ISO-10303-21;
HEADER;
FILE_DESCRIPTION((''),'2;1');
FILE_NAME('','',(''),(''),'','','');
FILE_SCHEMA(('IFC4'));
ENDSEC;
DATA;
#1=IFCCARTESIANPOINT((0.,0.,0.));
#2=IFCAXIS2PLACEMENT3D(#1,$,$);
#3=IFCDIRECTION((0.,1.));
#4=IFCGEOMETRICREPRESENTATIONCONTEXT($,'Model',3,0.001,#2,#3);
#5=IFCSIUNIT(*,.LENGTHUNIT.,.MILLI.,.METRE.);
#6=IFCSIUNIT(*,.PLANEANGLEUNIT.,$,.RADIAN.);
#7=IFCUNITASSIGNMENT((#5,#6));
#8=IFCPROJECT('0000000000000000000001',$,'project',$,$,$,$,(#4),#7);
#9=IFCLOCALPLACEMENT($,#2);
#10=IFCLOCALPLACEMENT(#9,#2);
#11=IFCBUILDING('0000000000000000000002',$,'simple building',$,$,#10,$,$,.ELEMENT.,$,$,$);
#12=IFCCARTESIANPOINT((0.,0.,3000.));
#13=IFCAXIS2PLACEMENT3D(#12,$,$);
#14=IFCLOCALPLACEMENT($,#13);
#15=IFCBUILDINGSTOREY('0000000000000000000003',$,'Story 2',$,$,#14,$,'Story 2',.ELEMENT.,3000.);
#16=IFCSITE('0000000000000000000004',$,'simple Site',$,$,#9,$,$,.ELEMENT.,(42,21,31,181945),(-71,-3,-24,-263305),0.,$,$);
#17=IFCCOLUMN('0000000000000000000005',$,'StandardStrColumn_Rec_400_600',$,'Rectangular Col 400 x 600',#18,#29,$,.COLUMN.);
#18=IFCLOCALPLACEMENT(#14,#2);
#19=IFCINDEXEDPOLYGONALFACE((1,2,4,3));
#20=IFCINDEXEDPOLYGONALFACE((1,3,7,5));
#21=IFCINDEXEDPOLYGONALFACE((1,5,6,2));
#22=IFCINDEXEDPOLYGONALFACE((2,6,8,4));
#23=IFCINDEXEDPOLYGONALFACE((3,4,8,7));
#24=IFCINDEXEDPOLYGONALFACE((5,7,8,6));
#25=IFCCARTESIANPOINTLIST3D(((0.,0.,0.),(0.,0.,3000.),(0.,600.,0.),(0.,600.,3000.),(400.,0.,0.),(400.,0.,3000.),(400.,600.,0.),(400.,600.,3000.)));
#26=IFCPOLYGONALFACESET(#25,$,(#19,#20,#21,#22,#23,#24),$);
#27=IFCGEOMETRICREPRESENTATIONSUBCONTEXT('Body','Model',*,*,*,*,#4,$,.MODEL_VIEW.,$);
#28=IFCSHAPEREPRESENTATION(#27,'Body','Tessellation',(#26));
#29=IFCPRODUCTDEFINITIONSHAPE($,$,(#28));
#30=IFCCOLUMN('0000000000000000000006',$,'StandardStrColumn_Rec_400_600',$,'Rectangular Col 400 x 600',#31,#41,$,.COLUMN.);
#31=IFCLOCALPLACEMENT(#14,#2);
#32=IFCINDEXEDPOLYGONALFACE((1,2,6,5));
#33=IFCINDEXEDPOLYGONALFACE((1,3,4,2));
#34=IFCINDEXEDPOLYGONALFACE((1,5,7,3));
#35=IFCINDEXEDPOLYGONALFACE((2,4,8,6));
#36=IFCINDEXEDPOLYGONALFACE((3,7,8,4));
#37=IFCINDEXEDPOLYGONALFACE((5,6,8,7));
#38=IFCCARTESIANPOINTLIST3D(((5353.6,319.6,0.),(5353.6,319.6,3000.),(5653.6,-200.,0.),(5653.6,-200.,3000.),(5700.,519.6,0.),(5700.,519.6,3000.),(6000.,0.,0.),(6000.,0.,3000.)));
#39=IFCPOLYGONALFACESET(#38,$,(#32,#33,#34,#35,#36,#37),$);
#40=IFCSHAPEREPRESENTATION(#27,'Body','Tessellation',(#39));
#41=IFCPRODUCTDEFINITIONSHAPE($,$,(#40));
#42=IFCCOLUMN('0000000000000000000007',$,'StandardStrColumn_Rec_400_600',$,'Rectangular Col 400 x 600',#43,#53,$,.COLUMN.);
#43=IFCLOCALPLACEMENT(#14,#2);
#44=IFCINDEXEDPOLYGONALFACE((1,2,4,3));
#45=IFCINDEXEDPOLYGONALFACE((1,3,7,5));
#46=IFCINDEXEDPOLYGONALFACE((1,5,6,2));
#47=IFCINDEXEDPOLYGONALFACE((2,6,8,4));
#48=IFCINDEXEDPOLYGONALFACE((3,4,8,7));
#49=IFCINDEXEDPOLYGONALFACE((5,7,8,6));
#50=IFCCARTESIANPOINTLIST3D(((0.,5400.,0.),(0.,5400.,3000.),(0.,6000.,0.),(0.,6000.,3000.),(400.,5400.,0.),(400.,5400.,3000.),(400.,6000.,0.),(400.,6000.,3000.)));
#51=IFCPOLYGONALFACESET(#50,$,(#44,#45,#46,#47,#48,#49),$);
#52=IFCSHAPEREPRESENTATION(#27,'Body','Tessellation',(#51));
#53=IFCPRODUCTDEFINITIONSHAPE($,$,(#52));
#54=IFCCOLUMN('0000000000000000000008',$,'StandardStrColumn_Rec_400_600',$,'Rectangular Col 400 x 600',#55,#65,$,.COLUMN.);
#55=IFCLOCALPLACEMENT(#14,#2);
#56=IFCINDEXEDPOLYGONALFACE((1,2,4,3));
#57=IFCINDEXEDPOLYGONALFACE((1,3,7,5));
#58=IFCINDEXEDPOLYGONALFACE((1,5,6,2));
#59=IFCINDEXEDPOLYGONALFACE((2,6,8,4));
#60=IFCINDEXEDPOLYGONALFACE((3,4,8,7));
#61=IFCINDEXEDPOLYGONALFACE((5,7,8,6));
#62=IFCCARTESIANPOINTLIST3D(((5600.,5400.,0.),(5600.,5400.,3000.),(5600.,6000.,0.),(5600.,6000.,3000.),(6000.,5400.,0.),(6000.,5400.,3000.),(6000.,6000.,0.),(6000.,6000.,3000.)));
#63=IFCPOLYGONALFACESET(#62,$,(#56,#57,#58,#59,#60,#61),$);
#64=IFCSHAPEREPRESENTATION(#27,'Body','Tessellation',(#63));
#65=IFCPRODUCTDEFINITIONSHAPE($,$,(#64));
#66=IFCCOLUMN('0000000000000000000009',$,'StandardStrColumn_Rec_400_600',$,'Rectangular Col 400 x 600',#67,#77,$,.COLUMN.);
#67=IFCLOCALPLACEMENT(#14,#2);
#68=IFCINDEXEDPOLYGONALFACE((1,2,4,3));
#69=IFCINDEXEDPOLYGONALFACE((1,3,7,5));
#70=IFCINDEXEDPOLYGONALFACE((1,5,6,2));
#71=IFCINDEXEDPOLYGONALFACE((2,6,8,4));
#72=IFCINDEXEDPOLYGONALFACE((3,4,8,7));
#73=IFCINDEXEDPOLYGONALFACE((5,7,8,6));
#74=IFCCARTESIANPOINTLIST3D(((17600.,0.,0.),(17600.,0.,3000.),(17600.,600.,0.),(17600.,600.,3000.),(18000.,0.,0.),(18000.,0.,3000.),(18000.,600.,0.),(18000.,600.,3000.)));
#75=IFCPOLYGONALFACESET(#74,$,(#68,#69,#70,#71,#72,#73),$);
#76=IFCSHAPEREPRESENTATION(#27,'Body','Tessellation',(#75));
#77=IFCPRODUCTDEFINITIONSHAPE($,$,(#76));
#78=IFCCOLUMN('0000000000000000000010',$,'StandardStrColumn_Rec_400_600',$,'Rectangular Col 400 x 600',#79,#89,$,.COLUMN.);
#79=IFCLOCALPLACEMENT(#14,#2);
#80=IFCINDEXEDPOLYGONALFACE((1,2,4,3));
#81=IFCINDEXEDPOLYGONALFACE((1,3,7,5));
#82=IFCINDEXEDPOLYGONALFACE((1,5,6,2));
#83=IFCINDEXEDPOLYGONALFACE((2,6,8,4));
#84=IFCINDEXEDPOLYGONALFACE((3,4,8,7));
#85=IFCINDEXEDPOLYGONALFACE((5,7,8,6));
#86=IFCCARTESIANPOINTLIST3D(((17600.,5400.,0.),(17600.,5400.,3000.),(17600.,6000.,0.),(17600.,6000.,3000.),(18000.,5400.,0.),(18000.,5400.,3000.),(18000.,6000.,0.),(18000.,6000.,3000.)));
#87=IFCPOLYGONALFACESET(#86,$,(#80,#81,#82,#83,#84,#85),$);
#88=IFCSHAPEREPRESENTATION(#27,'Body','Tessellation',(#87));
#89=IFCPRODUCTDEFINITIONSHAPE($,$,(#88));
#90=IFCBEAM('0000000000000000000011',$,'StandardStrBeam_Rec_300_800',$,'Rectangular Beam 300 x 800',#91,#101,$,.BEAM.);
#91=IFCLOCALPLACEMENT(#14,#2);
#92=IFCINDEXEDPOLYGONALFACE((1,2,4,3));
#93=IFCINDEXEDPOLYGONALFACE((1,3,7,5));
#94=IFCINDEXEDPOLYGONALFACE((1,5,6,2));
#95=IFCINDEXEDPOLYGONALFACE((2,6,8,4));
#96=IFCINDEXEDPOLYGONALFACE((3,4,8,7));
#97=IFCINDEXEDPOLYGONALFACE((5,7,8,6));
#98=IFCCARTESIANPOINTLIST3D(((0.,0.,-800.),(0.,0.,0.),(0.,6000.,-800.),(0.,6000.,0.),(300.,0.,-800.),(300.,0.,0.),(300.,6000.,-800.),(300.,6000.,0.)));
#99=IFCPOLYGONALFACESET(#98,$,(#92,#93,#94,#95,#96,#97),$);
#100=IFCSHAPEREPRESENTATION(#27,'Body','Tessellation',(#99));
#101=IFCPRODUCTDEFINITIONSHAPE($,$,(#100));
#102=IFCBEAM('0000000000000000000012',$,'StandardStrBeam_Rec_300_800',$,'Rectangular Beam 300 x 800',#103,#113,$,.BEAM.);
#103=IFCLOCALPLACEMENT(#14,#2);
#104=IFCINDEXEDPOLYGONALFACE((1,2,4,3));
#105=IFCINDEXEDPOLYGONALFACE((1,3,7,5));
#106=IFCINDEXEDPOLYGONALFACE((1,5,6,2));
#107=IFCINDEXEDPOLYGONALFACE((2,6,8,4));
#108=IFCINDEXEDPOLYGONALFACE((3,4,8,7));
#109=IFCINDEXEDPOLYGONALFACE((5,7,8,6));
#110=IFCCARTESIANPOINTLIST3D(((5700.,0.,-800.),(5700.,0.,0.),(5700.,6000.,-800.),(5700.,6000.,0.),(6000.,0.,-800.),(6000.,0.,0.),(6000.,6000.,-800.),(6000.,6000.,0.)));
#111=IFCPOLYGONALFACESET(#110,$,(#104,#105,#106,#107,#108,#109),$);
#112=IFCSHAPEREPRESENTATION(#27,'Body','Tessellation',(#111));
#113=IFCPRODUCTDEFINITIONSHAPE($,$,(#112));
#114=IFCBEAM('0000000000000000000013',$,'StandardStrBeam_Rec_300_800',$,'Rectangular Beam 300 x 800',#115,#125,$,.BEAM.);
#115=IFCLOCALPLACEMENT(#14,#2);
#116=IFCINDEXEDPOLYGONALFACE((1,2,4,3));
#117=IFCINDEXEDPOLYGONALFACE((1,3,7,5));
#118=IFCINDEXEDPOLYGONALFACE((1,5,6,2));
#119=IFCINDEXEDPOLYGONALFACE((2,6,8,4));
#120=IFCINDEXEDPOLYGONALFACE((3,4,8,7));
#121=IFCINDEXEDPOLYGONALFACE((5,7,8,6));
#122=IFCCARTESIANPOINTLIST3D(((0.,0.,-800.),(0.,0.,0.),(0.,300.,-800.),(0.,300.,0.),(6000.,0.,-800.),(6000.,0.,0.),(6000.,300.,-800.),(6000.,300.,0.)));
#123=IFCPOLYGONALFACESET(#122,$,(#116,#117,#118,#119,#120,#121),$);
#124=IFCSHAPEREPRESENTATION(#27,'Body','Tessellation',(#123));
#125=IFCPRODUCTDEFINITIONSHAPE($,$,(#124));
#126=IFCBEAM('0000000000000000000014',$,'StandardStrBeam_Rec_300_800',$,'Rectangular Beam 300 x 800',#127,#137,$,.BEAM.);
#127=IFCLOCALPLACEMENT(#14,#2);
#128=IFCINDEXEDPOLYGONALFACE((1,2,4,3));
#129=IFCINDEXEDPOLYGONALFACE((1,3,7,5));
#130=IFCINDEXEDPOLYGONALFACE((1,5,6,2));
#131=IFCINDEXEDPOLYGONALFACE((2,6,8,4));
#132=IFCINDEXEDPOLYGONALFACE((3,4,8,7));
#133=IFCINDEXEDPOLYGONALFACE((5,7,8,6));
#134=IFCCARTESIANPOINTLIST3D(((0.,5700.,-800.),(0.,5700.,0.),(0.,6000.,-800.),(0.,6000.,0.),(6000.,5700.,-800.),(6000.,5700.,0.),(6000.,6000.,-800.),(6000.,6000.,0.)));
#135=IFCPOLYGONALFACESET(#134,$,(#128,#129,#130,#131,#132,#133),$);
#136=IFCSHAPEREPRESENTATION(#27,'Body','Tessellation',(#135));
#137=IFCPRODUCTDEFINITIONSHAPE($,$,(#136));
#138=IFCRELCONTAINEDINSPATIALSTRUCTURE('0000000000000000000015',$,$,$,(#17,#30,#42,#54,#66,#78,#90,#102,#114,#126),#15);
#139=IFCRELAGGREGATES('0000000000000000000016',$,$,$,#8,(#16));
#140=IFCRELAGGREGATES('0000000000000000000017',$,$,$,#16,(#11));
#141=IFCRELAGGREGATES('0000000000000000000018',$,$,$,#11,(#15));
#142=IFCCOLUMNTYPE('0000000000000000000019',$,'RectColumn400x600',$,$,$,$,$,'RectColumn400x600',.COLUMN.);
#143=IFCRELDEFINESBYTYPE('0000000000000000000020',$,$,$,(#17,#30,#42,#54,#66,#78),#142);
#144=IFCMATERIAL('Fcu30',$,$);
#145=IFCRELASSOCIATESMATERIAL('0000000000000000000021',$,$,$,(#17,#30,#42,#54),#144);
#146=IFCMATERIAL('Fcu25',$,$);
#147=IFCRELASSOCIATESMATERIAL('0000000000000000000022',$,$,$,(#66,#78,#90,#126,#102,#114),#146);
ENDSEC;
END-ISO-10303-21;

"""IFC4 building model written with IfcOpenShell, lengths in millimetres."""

from ifc_helpers import new_model, si_unit, direction, frame, origin, origin_with_axes, origin_2d_with_axis, place, context, subcontext, project, spatial, rectangle, extrude, material, material_profile, profile_set, profile_usage, type_object, element, save


model = new_model("IFC4")

# Units and contexts
model_context = context("Model", 3, precision=0.001, world=origin(), true_north=direction((0.0, 1.0)))
body_context = subcontext(model_context, "Body", "Model", "MODEL_VIEW")
ifc_project = project(units=[si_unit("LENGTHUNIT", "METRE", prefix="MILLI"), si_unit("PLANEANGLEUNIT", "RADIAN")], contexts=[model_context])

# Site, building, storey
site_placement = place(None, origin())
site = spatial("IfcSite", under=ifc_project, at=site_placement, Name="simple Site", CompositionType="ELEMENT", RefLatitude=(42, 21, 31, 181945), RefLongitude=(-71, -3, -24, -263305), RefElevation=0.0)
building_placement = place(site_placement, origin())
building = spatial("IfcBuilding", under=site, at=building_placement, Name="simple building", CompositionType="ELEMENT")
storey_placement = place(None, frame((0.0, 0.0, 3000.0)))
storey = spatial("IfcBuildingStorey", under=building, at=storey_placement, Name="Story 2", LongName="Story 2", CompositionType="ELEMENT", Elevation=3000.0)

# Columns
ifc_material_1 = material(Name="Fcu30")
ifc_material_profile_1 = material_profile(ifc_material_1, rectangle(XDim=400.0, YDim=600.0, at=origin_2d_with_axis()))
ifc_profile_set_1 = profile_set([ifc_material_profile_1])
ifc_profile_usage_1 = profile_usage(ifc_profile_set_1, cardinal=7)
column_type = type_object("IfcColumnType", Name="RectColumn400x600", ElementType="RectColumn400x600", PredefinedType="COLUMN")
column_1_placement = place(None, frame((200.0, 300.0, 3000.0), z_axis=(0.0, 0.0, 1.0), x_axis=(1.0, 0.0, 0.0)))
element("IfcColumn", 1, at=column_1_placement, inside=storey, type_object=column_type, material=ifc_profile_usage_1, Name="StandardStrColumn_Rec_400_600", ObjectType="Rectangular Col 400 x 600", PredefinedType="COLUMN", context=body_context, shape_type="SweptSolid", body=[
    extrude(rectangle(XDim=400.0, YDim=600.0, at=origin_2d_with_axis()), origin_with_axes(), (0.0, 0.0, 1.0), 3000.0),
])
ifc_profile_usage_2 = profile_usage(ifc_profile_set_1, cardinal=9)
column_2_placement = place(None, frame((5676.8, 159.8, 3000.0), z_axis=(0.0, 0.0, 1.0), x_axis=(0.866025, 0.5, 0.0)))
element("IfcColumn", 2, at=column_2_placement, inside=storey, type_object=column_type, material=ifc_profile_usage_2, Name="StandardStrColumn_Rec_400_600", ObjectType="Rectangular Col 400 x 600", PredefinedType="COLUMN", context=body_context, shape_type="SweptSolid", body=[
    extrude(rectangle(XDim=400.0, YDim=600.0, at=origin_2d_with_axis()), origin_with_axes(), (0.0, 0.0, 1.0), 3000.0),
])
ifc_profile_usage_3 = profile_usage(ifc_profile_set_1, cardinal=1)
column_3_placement = place(None, frame((200.0, 5700.0, 3000.0), z_axis=(0.0, 0.0, 1.0), x_axis=(1.0, 0.0, 0.0)))
element("IfcColumn", 3, at=column_3_placement, inside=storey, type_object=column_type, material=ifc_profile_usage_3, Name="StandardStrColumn_Rec_400_600", ObjectType="Rectangular Col 400 x 600", PredefinedType="COLUMN", context=body_context, shape_type="SweptSolid", body=[
    extrude(rectangle(XDim=400.0, YDim=600.0, at=origin_2d_with_axis()), origin_with_axes(), (0.0, 0.0, 1.0), 3000.0),
])
ifc_profile_usage_4 = profile_usage(ifc_profile_set_1, cardinal=3)
column_4_placement = place(None, frame((5800.0, 5700.0, 3000.0), z_axis=(0.0, 0.0, 1.0), x_axis=(1.0, 0.0, 0.0)))
element("IfcColumn", 4, at=column_4_placement, inside=storey, type_object=column_type, material=ifc_profile_usage_4, Name="StandardStrColumn_Rec_400_600", ObjectType="Rectangular Col 400 x 600", PredefinedType="COLUMN", context=body_context, shape_type="SweptSolid", body=[
    extrude(rectangle(XDim=400.0, YDim=600.0, at=origin_2d_with_axis()), origin_with_axes(), (0.0, 0.0, 1.0), 3000.0),
])
ifc_material_2 = material(Name="Fcu25")
ifc_material_profile_2 = material_profile(ifc_material_2, rectangle(XDim=400.0, YDim=600.0, at=origin_2d_with_axis()))
ifc_profile_set_2 = profile_set([ifc_material_profile_2])
ifc_profile_usage_5 = profile_usage(ifc_profile_set_2, cardinal=9)
column_5_placement = place(None, frame((17800.0, 300.0, 3000.0), z_axis=(0.0, 0.0, 1.0), x_axis=(1.0, 0.0, 0.0)))
element("IfcColumn", 5, at=column_5_placement, inside=storey, type_object=column_type, material=ifc_profile_usage_5, Name="StandardStrColumn_Rec_400_600", ObjectType="Rectangular Col 400 x 600", PredefinedType="COLUMN", context=body_context, shape_type="SweptSolid", body=[
    extrude(rectangle(XDim=400.0, YDim=600.0, at=origin_2d_with_axis()), origin_with_axes(), (0.0, 0.0, 1.0), 3000.0),
])
ifc_profile_usage_6 = profile_usage(ifc_profile_set_2, cardinal=3)
column_6_placement = place(None, frame((17800.0, 5700.0, 3000.0), z_axis=(0.0, 0.0, 1.0), x_axis=(1.0, 0.0, 0.0)))
element("IfcColumn", 6, at=column_6_placement, inside=storey, type_object=column_type, material=ifc_profile_usage_6, Name="StandardStrColumn_Rec_400_600", ObjectType="Rectangular Col 400 x 600", PredefinedType="COLUMN", context=body_context, shape_type="SweptSolid", body=[
    extrude(rectangle(XDim=400.0, YDim=600.0, at=origin_2d_with_axis()), origin_with_axes(), (0.0, 0.0, 1.0), 3000.0),
])

# Beams
ifc_material_profile_3 = material_profile(ifc_material_2, rectangle(XDim=300.0, YDim=800.0, at=origin_2d_with_axis()))
ifc_profile_set_3 = profile_set([ifc_material_profile_3])
ifc_profile_usage_7 = profile_usage(ifc_profile_set_3, cardinal=7)
beam_1_placement = place(None, frame((150.0, 0.0, 2600.0), z_axis=(0.0, 1.0, 0.0), x_axis=(1.0, 0.0, 0.0)))
element("IfcBeam", 7, at=beam_1_placement, inside=storey, material=ifc_profile_usage_7, Name="StandardStrBeam_Rec_300_800", ObjectType="Rectangular Beam 300 x 800", PredefinedType="BEAM", context=body_context, shape_type="SweptSolid", body=[
    extrude(rectangle(XDim=300.0, YDim=800.0, at=origin_2d_with_axis()), origin_with_axes(), (0.0, 0.0, 1.0), 6000.0),
])
ifc_profile_usage_8 = profile_usage(ifc_profile_set_3, cardinal=9)
for number, where, z_axis, x_axis, name in (
    (8, (5850.0, 0.0, 2600.0), (0.0, 1.0, 0.0), (1.0, 0.0, 0.0), "StandardStrBeam_Rec_300_800"),
    (9, (0.0, 150.0, 2600.0), (1.0, 0.0, 0.0), (0.0, -1.0, 0.0), "StandardStrBeam_Rec_300_800"),
):
    element("IfcBeam", number, at=place(None, frame(where, z_axis=z_axis, x_axis=x_axis)), inside=storey, material=ifc_profile_usage_8, Name=name, ObjectType="Rectangular Beam 300 x 800", PredefinedType="BEAM", context=body_context, shape_type="SweptSolid", body=[
        extrude(rectangle(XDim=300.0, YDim=800.0, at=origin_2d_with_axis()), origin_with_axes(), (0.0, 0.0, 1.0), 6000.0),
    ])
beam_2_placement = place(None, frame((0.0, 5850.0, 2600.0), z_axis=(1.0, 0.0, 0.0), x_axis=(0.0, -1.0, 0.0)))
element("IfcBeam", 10, at=beam_2_placement, inside=storey, material=ifc_profile_usage_7, Name="StandardStrBeam_Rec_300_800", ObjectType="Rectangular Beam 300 x 800", PredefinedType="BEAM", context=body_context, shape_type="SweptSolid", body=[
    extrude(rectangle(XDim=300.0, YDim=800.0, at=origin_2d_with_axis()), origin_with_axes(), (0.0, 0.0, 1.0), 6000.0),
])

save(model, "model.ifc")
